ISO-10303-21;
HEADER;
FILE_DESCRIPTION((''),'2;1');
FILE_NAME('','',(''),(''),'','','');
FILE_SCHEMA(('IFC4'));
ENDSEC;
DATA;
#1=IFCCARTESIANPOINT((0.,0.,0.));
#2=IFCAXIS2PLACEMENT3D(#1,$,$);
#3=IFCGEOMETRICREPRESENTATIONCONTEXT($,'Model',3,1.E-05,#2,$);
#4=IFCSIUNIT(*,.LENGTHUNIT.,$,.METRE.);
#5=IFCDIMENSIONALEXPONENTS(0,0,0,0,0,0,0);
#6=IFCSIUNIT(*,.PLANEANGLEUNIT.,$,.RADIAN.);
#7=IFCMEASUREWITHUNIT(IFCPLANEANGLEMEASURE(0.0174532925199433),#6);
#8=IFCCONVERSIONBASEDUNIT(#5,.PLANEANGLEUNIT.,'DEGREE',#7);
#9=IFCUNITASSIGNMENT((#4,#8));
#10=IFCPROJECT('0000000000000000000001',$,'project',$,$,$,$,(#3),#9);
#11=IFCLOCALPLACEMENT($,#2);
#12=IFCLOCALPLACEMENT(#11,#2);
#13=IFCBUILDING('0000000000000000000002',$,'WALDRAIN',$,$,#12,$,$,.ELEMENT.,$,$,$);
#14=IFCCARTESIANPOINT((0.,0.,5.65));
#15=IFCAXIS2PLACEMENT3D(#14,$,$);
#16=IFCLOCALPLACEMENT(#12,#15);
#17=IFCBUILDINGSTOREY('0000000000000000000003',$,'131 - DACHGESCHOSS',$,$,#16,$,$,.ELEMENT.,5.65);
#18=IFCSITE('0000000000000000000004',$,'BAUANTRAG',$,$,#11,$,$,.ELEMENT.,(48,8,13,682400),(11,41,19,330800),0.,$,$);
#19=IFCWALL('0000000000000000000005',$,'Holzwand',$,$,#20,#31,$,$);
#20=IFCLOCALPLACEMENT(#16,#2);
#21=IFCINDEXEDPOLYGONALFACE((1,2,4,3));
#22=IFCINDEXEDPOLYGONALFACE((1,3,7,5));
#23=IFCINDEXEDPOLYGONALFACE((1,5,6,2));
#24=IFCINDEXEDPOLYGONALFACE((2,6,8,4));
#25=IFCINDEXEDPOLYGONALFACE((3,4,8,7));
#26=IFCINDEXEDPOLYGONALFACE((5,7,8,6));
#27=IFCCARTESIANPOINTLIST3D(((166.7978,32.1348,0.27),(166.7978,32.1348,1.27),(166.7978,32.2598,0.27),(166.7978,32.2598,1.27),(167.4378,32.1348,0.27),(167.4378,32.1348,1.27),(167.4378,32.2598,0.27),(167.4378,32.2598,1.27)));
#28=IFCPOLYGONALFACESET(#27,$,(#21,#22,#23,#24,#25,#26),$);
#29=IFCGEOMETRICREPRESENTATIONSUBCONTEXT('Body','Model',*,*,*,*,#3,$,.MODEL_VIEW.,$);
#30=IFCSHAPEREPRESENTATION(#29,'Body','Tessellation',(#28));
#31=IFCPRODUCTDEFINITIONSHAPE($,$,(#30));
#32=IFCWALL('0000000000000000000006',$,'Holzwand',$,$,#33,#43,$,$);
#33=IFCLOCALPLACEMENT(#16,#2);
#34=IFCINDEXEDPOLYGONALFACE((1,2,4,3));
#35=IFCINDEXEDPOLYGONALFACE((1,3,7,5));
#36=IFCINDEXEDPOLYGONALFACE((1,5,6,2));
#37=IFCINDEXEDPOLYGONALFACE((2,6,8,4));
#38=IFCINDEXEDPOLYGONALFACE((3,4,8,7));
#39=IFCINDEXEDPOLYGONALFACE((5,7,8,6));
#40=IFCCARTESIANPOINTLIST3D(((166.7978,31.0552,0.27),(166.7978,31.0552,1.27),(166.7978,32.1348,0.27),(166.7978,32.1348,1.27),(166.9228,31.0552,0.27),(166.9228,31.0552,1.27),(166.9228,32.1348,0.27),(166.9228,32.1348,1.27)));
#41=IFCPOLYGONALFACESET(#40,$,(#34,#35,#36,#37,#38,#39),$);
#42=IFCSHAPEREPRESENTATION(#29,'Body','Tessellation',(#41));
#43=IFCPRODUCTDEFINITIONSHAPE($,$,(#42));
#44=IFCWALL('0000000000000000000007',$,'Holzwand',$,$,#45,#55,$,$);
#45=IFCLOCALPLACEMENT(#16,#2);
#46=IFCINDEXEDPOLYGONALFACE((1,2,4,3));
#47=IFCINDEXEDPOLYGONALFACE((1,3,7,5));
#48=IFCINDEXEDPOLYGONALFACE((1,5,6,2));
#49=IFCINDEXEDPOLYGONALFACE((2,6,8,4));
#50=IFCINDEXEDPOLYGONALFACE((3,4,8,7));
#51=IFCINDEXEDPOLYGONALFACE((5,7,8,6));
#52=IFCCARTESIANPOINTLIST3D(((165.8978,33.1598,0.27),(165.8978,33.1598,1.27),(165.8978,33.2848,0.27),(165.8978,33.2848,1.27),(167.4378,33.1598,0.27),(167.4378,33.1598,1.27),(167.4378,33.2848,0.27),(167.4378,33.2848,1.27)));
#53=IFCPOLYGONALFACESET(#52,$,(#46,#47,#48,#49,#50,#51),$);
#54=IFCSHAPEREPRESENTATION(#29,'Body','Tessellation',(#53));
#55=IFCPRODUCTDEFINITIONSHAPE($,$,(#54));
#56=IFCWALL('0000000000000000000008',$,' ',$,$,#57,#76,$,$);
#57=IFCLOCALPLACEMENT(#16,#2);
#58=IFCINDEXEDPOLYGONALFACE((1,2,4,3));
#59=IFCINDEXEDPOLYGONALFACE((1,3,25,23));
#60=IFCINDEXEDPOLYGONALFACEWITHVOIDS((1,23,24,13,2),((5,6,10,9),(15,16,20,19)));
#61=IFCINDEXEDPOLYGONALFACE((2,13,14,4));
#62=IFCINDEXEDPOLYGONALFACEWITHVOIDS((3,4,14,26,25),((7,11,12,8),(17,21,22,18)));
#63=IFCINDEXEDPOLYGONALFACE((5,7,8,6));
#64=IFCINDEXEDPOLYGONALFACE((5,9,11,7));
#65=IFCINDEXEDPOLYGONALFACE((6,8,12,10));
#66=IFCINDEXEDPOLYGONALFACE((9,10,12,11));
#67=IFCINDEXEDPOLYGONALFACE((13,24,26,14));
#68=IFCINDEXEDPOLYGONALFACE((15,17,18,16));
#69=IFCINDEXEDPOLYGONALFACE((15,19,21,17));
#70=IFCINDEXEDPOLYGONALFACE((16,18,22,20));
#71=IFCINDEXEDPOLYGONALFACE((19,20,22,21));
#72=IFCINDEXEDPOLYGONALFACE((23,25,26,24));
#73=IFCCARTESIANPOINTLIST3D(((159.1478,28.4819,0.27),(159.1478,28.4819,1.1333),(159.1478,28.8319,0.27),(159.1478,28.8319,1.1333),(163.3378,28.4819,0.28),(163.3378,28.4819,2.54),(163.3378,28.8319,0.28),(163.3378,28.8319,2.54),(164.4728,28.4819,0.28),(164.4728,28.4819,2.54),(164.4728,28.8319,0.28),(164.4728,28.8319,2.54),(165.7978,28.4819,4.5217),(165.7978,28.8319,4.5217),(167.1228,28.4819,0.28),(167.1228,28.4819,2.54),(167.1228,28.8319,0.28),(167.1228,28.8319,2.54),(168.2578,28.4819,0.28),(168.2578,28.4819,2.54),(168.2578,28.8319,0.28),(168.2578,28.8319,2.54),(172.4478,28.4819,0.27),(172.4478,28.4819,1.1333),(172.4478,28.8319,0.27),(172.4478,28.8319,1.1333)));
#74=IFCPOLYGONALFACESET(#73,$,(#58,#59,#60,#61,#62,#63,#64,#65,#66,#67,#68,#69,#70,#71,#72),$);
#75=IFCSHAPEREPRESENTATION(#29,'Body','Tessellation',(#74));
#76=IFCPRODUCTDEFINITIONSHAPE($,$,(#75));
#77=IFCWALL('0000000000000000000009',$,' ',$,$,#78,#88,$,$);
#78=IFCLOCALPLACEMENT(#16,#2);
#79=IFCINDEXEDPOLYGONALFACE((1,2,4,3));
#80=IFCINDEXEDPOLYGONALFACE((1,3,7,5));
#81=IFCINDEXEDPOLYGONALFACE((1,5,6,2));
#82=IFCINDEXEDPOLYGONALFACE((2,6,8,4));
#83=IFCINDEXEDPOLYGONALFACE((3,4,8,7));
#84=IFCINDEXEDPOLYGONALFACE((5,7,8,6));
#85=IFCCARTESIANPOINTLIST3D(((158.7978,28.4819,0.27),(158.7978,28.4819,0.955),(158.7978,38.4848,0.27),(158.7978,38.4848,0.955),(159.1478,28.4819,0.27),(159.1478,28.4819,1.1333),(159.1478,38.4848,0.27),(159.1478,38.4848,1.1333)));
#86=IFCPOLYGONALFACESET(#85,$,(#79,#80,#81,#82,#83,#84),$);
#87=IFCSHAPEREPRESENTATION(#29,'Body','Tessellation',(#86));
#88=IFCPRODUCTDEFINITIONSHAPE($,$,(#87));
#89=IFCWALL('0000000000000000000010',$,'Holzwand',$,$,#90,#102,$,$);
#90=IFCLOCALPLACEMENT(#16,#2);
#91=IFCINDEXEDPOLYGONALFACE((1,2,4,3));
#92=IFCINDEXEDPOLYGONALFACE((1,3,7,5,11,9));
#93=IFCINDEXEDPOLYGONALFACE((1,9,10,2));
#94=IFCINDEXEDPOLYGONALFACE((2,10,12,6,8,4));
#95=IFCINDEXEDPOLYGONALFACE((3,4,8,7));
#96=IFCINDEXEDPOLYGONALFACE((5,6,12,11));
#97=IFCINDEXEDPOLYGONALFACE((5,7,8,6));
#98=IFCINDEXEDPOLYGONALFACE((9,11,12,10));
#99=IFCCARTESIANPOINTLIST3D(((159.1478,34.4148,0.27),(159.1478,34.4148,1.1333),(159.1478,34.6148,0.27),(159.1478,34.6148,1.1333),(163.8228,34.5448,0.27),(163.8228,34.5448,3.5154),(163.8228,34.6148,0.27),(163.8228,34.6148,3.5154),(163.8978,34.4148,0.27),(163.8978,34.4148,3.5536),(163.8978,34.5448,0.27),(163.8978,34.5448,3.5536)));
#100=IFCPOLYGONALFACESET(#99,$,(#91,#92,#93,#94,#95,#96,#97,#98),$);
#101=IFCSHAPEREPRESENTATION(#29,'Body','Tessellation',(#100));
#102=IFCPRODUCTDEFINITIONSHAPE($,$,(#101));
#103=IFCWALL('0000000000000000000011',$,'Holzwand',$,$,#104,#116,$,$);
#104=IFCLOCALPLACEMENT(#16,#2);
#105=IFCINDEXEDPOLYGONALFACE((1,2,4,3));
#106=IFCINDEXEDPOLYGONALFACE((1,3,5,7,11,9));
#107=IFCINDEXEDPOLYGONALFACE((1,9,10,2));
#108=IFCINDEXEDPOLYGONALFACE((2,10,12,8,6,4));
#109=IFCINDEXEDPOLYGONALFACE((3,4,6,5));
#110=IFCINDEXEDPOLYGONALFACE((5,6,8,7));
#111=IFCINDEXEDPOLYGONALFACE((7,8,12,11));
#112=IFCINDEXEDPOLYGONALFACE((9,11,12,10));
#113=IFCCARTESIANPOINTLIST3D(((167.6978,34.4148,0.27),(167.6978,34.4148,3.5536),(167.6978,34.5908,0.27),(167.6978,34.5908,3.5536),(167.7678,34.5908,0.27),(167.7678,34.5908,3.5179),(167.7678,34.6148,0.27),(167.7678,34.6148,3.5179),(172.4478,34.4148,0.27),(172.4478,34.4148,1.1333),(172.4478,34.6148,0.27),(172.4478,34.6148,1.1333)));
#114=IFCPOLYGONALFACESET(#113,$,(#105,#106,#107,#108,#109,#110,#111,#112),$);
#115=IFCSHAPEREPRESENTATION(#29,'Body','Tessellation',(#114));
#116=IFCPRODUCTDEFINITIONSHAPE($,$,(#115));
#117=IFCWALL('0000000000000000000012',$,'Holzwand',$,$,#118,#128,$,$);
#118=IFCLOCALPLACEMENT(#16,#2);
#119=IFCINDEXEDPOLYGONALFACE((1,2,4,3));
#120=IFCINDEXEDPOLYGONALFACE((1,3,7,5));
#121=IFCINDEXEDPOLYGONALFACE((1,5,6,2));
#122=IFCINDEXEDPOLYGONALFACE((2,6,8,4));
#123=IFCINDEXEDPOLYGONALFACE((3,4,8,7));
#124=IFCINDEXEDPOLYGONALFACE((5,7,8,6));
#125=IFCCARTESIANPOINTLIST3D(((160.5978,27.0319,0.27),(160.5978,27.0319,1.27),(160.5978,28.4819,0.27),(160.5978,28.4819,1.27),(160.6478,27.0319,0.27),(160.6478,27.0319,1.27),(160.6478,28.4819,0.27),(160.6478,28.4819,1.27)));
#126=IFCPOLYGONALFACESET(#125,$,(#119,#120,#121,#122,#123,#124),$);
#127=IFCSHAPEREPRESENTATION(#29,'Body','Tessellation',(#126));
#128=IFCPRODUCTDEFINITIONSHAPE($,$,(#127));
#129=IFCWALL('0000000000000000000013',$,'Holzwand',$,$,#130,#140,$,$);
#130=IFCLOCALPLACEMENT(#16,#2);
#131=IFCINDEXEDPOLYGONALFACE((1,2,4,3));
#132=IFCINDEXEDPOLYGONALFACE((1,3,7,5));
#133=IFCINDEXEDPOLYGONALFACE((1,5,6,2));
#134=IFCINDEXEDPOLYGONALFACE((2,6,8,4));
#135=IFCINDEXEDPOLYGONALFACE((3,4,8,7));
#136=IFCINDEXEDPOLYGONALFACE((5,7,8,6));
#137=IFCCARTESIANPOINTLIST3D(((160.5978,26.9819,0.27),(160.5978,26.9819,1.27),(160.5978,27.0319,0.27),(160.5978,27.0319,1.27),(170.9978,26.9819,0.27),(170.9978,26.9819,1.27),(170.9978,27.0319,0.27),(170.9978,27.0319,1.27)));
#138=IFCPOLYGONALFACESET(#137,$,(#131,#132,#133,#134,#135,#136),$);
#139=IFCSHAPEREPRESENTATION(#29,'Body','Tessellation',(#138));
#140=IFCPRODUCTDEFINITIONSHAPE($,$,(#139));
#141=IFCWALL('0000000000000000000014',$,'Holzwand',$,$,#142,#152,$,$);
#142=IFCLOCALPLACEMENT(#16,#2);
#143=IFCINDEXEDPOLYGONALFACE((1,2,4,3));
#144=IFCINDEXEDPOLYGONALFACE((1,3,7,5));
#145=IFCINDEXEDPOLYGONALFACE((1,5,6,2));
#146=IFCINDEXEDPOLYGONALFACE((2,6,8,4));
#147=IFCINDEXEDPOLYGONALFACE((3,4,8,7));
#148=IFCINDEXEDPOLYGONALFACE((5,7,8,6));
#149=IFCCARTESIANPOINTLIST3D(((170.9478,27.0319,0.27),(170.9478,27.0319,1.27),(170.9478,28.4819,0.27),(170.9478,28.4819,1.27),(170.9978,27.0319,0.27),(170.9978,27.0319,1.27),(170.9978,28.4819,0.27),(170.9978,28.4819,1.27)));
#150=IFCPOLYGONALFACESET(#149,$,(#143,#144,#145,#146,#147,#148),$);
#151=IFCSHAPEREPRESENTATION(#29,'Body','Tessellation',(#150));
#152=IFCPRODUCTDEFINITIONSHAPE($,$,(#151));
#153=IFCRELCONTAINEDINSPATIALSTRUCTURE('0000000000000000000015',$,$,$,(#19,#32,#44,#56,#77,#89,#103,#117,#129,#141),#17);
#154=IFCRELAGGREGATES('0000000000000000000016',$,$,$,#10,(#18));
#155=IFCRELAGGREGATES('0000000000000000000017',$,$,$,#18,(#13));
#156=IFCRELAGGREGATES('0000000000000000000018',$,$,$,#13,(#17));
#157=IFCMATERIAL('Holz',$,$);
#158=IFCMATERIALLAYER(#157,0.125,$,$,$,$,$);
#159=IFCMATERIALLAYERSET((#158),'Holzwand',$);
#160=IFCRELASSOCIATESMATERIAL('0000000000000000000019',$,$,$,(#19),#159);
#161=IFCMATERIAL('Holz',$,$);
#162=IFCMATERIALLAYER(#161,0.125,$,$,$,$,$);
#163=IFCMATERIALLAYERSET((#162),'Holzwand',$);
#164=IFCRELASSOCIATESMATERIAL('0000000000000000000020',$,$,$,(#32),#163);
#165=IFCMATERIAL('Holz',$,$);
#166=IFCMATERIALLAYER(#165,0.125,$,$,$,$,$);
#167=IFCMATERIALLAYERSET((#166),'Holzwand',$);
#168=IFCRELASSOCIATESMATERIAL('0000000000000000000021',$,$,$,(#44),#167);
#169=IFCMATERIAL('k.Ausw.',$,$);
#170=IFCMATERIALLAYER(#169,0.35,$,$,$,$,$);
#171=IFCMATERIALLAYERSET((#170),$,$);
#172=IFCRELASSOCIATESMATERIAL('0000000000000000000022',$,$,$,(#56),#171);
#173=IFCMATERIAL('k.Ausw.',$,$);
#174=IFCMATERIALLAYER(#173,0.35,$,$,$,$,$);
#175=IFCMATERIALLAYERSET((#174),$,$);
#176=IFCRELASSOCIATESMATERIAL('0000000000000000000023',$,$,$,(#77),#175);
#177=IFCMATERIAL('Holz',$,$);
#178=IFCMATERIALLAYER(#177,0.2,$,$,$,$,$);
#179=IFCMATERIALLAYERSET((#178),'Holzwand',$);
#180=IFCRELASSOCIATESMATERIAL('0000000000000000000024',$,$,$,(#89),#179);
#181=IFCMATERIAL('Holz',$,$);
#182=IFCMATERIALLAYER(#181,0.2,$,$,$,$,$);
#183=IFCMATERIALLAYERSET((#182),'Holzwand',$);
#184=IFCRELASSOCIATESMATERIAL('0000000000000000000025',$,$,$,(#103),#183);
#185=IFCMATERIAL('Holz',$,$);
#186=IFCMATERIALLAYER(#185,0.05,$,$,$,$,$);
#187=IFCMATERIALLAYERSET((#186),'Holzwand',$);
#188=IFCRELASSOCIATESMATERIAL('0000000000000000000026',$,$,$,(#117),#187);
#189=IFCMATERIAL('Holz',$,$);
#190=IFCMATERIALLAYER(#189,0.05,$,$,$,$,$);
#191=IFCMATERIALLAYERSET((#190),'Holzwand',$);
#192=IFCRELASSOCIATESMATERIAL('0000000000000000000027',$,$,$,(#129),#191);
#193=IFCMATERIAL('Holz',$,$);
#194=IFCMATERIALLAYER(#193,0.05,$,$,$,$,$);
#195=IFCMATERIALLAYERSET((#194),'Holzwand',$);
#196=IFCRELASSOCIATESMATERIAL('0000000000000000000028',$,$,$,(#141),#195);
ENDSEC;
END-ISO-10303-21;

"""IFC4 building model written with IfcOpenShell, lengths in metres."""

from ifc_helpers import new_model, entity, si_unit, converted_unit, frame, frame_2d, origin, origin_with_axes, place, context, subcontext, project, spatial, polyline, rectangle, outline, extrude, clip, halfspace, bounded_halfspace, material, layer, layer_set, layer_usage, element, save


model = new_model("IFC4")

# Units and contexts
model_context = context("Model", 3, precision=1e-05, world=origin())
body_context = subcontext(model_context, "Body", "Model", "MODEL_VIEW")
ifc_project = project(units=[si_unit("LENGTHUNIT", "METRE"), converted_unit("PLANEANGLEUNIT", "DEGREE", entity("IfcPlaneAngleMeasure", 0.0174532925199433), si_unit("PLANEANGLEUNIT", "RADIAN"), dimensions=[0, 0, 0, 0, 0, 0, 0])], contexts=[model_context])

# Site, building, storey
site_placement = place(None, origin())
site = spatial("IfcSite", under=ifc_project, at=site_placement, Name="BAUANTRAG", CompositionType="ELEMENT", RefLatitude=(48, 8, 13, 682400), RefLongitude=(11, 41, 19, 330800), RefElevation=0.0)
building_placement = place(site_placement, origin())
building = spatial("IfcBuilding", under=site, at=building_placement, Name="WALDRAIN", CompositionType="ELEMENT")
storey_placement = place(building_placement, frame((0.0, 0.0, 5.65)))
storey = spatial("IfcBuildingStorey", under=building, at=storey_placement, Name="131 - DACHGESCHOSS", CompositionType="ELEMENT", Elevation=5.65)

# Walls
ifc_material_1 = material(Name="Holz")
ifc_layer_1 = layer(ifc_material_1, 0.125)
ifc_layer_set_1 = layer_set([ifc_layer_1], Name="Holzwand")
ifc_layer_usage_1 = layer_usage(ifc_layer_set_1, "AXIS2", "POSITIVE", 0.0)
wall_1_placement = place(storey_placement, frame((167.4378, 32.2598, 0.27), z_axis=(0.0, 0.0, 1.0), x_axis=(-1.0, 0.0, 0.0)))
element("IfcWall", 1, at=wall_1_placement, inside=storey, material=ifc_layer_usage_1, Name="Holzwand", context=body_context, shape_type="SweptSolid", body=[
    extrude(rectangle(XDim=0.64, YDim=0.125, at=frame_2d((0.32, 0.0625), x_axis=(1.0, 0.0))), origin_with_axes(), (0.0, 0.0, 1.0), 1.0),
])
ifc_material_2 = material(Name="Holz")
ifc_layer_2 = layer(ifc_material_2, 0.125)
ifc_layer_set_2 = layer_set([ifc_layer_2], Name="Holzwand")
ifc_layer_usage_2 = layer_usage(ifc_layer_set_2, "AXIS2", "POSITIVE", 0.0)
wall_2_placement = place(storey_placement, frame((166.7978, 32.1348, 0.27), z_axis=(0.0, 0.0, 1.0), x_axis=(0.0, -1.0, 0.0)))
element("IfcWall", 2, at=wall_2_placement, inside=storey, material=ifc_layer_usage_2, Name="Holzwand", context=body_context, shape_type="SweptSolid", body=[
    extrude(rectangle(XDim=1.0796, YDim=0.125, at=frame_2d((0.5398, 0.0625), x_axis=(1.0, 0.0))), origin_with_axes(), (0.0, 0.0, 1.0), 1.0),
])
ifc_material_3 = material(Name="Holz")
ifc_layer_3 = layer(ifc_material_3, 0.125)
ifc_layer_set_3 = layer_set([ifc_layer_3], Name="Holzwand")
ifc_layer_usage_3 = layer_usage(ifc_layer_set_3, "AXIS2", "POSITIVE", 0.0)
wall_3_placement = place(storey_placement, frame((165.8978, 33.1598, 0.27)))
element("IfcWall", 3, at=wall_3_placement, inside=storey, material=ifc_layer_usage_3, Name="Holzwand", context=body_context, shape_type="SweptSolid", body=[
    extrude(rectangle(XDim=1.54, YDim=0.125, at=frame_2d((0.77, 0.0625), x_axis=(1.0, 0.0))), origin_with_axes(), (0.0, 0.0, 1.0), 1.0),
])

# Wall, openings
ifc_material_4 = material(Name="k.Ausw.")
ifc_layer_4 = layer(ifc_material_4, 0.35)
ifc_layer_set_4 = layer_set([ifc_layer_4])
ifc_layer_usage_4 = layer_usage(ifc_layer_set_4, "AXIS2", "POSITIVE", 0.0)
wall_4_placement = place(storey_placement, frame((159.1478, 28.4819, 0.27)))
wall_4 = element("IfcWall", 4, at=wall_4_placement, inside=storey, material=ifc_layer_usage_4, Name=" ", context=body_context, shape_type="Clipping", body=[
    clip(clip(extrude(rectangle(XDim=13.3, YDim=0.35, at=frame_2d((6.65, 0.175), x_axis=(1.0, 0.0))), origin_with_axes(), (0.0, 0.0, 1.0), 4.2517), bounded_halfspace(frame((3.325, 0.175, 2.5575), z_axis=(0.45399, 0.0, -0.891007), x_axis=(0.0, -1.0, 0.0)), True, origin_with_axes(), polyline([(0.0, 0.35), (0.0, 0.0), (6.65, 0.0), (6.65, 0.35), (0.0, 0.35)]))), bounded_halfspace(frame((9.975, 0.175, 2.5575), z_axis=(-0.45399, 0.0, -0.891007), x_axis=(0.891007, 0.0, -0.45399)), True, origin_with_axes(), polyline([(6.65, 0.0), (13.3, 0.0), (13.3, 0.35), (6.65, 0.35), (6.65, 0.0)]))),
])
opening_1_placement = place(wall_4_placement, frame((5.325, 0.35, 0.01), z_axis=(0.0, -1.0, 0.0), x_axis=(0.0, 0.0, 1.0)))
element("IfcOpeningElement", 5, at=opening_1_placement, cuts=wall_4, ObjectType="Opening", context=body_context, shape_type="SweptSolid", body=[
    extrude(outline(polyline([(0.0, 1.135), (2.26, 1.135), (2.26, 0.0), (0.0, 0.0), (0.0, 1.135)])), origin_with_axes(), (0.0, 0.0, 1.0), 0.35),
])
opening_2_placement = place(wall_4_placement, frame((9.11, 0.35, 0.01), z_axis=(0.0, -1.0, 0.0), x_axis=(0.0, 0.0, 1.0)))
element("IfcOpeningElement", 6, at=opening_2_placement, cuts=wall_4, ObjectType="Opening", context=body_context, shape_type="SweptSolid", body=[
    extrude(outline(polyline([(0.0, 1.135), (2.26, 1.135), (2.26, 0.0), (0.0, 0.0), (0.0, 1.135)])), origin_with_axes(), (0.0, 0.0, 1.0), 0.35),
])

# Walls
ifc_material_5 = material(Name="k.Ausw.")
ifc_layer_5 = layer(ifc_material_5, 0.35)
ifc_layer_set_5 = layer_set([ifc_layer_5])
ifc_layer_usage_5 = layer_usage(ifc_layer_set_5, "AXIS2", "POSITIVE", 0.0)
wall_5_placement = place(storey_placement, frame((158.7978, 38.4848, 0.27), z_axis=(0.0, 0.0, 1.0), x_axis=(0.0, -1.0, 0.0)))
element("IfcWall", 7, at=wall_5_placement, inside=storey, material=ifc_layer_usage_5, Name=" ", context=body_context, shape_type="Clipping", body=[
    clip(extrude(rectangle(XDim=10.0029, YDim=0.35, at=frame_2d((5.0014, 0.175), x_axis=(1.0, 0.0))), origin_with_axes(), (0.0, 0.0, 1.0), 0.8633), halfspace(frame((5.0014, 0.175, 0.7742), z_axis=(0.0, 0.45399, -0.891007), x_axis=(0.0, -0.891007, -0.45399)), True)),
])
ifc_material_6 = material(Name="Holz")
ifc_layer_6 = layer(ifc_material_6, 0.2)
ifc_layer_set_6 = layer_set([ifc_layer_6], Name="Holzwand")
ifc_layer_usage_6 = layer_usage(ifc_layer_set_6, "AXIS2", "POSITIVE", 0.0)
wall_6_placement = place(storey_placement, frame((159.1478, 34.4148, 0.27)))
element("IfcWall", 8, at=wall_6_placement, inside=storey, material=ifc_layer_usage_6, Name="Holzwand", context=body_context, shape_type="Clipping", body=[
    clip(extrude(outline(polyline([(0.0, 0.0), (4.75, 0.0), (4.75, 0.13), (4.675, 0.13), (4.675, 0.2), (0.0, 0.2), (0.0, 0.0)])), origin_with_axes(), (0.0, 0.0, 1.0), 3.2836), halfspace(frame((3.1417, 0.11, 2.4641), z_axis=(0.45399, 0.0, -0.891007), x_axis=(0.891007, 0.0, 0.45399)), True)),
])
ifc_material_7 = material(Name="Holz")
ifc_layer_7 = layer(ifc_material_7, 0.2)
ifc_layer_set_7 = layer_set([ifc_layer_7], Name="Holzwand")
ifc_layer_usage_7 = layer_usage(ifc_layer_set_7, "AXIS2", "POSITIVE", 0.0)
wall_7_placement = place(storey_placement, frame((167.6978, 34.4148, 0.27)))
element("IfcWall", 9, at=wall_7_placement, inside=storey, material=ifc_layer_usage_7, Name="Holzwand", context=body_context, shape_type="Clipping", body=[
    clip(extrude(outline(polyline([(0.0, 0.0), (4.75, 0.0), (4.75, 0.2), (0.07, 0.2), (0.07, 0.176), (0.0, 0.176), (0.0, 0.0)])), origin_with_axes(), (0.0, 0.0, 1.0), 3.2836), halfspace(frame((1.6067, 0.1253, 2.4649), z_axis=(-0.45399, 0.0, -0.891007), x_axis=(0.891007, 0.0, -0.45399)), True)),
])
ifc_material_8 = material(Name="Holz")
ifc_layer_8 = layer(ifc_material_8, 0.05)
ifc_layer_set_8 = layer_set([ifc_layer_8], Name="Holzwand")
ifc_layer_usage_8 = layer_usage(ifc_layer_set_8, "AXIS2", "POSITIVE", 0.0)
wall_8_placement = place(storey_placement, frame((160.5978, 28.4819, 0.27), z_axis=(0.0, 0.0, 1.0), x_axis=(0.0, -1.0, 0.0)))
element("IfcWall", 10, at=wall_8_placement, inside=storey, material=ifc_layer_usage_8, Name="Holzwand", context=body_context, shape_type="SweptSolid", body=[
    extrude(rectangle(XDim=1.45, YDim=0.05, at=frame_2d((0.725, 0.025), x_axis=(1.0, 0.0))), origin_with_axes(), (0.0, 0.0, 1.0), 1.0),
])
ifc_material_9 = material(Name="Holz")
ifc_layer_9 = layer(ifc_material_9, 0.05)
ifc_layer_set_9 = layer_set([ifc_layer_9], Name="Holzwand")
ifc_layer_usage_9 = layer_usage(ifc_layer_set_9, "AXIS2", "POSITIVE", 0.0)
wall_9_placement = place(storey_placement, frame((160.5978, 26.9819, 0.27)))
element("IfcWall", 11, at=wall_9_placement, inside=storey, material=ifc_layer_usage_9, Name="Holzwand", context=body_context, shape_type="SweptSolid", body=[
    extrude(rectangle(XDim=10.4, YDim=0.05, at=frame_2d((5.2, 0.025), x_axis=(1.0, 0.0))), origin_with_axes(), (0.0, 0.0, 1.0), 1.0),
])
ifc_material_10 = material(Name="Holz")
ifc_layer_10 = layer(ifc_material_10, 0.05)
ifc_layer_set_10 = layer_set([ifc_layer_10], Name="Holzwand")
ifc_layer_usage_10 = layer_usage(ifc_layer_set_10, "AXIS2", "POSITIVE", 0.0)
wall_10_placement = place(storey_placement, frame((170.9978, 27.0319, 0.27), z_axis=(0.0, 0.0, 1.0), x_axis=(0.0, 1.0, 0.0)))
element("IfcWall", 12, at=wall_10_placement, inside=storey, material=ifc_layer_usage_10, Name="Holzwand", context=body_context, shape_type="SweptSolid", body=[
    extrude(rectangle(XDim=1.45, YDim=0.05, at=frame_2d((0.725, 0.025), x_axis=(1.0, 0.0))), origin_with_axes(), (0.0, 0.0, 1.0), 1.0),
])

save(model, "model.ifc")
